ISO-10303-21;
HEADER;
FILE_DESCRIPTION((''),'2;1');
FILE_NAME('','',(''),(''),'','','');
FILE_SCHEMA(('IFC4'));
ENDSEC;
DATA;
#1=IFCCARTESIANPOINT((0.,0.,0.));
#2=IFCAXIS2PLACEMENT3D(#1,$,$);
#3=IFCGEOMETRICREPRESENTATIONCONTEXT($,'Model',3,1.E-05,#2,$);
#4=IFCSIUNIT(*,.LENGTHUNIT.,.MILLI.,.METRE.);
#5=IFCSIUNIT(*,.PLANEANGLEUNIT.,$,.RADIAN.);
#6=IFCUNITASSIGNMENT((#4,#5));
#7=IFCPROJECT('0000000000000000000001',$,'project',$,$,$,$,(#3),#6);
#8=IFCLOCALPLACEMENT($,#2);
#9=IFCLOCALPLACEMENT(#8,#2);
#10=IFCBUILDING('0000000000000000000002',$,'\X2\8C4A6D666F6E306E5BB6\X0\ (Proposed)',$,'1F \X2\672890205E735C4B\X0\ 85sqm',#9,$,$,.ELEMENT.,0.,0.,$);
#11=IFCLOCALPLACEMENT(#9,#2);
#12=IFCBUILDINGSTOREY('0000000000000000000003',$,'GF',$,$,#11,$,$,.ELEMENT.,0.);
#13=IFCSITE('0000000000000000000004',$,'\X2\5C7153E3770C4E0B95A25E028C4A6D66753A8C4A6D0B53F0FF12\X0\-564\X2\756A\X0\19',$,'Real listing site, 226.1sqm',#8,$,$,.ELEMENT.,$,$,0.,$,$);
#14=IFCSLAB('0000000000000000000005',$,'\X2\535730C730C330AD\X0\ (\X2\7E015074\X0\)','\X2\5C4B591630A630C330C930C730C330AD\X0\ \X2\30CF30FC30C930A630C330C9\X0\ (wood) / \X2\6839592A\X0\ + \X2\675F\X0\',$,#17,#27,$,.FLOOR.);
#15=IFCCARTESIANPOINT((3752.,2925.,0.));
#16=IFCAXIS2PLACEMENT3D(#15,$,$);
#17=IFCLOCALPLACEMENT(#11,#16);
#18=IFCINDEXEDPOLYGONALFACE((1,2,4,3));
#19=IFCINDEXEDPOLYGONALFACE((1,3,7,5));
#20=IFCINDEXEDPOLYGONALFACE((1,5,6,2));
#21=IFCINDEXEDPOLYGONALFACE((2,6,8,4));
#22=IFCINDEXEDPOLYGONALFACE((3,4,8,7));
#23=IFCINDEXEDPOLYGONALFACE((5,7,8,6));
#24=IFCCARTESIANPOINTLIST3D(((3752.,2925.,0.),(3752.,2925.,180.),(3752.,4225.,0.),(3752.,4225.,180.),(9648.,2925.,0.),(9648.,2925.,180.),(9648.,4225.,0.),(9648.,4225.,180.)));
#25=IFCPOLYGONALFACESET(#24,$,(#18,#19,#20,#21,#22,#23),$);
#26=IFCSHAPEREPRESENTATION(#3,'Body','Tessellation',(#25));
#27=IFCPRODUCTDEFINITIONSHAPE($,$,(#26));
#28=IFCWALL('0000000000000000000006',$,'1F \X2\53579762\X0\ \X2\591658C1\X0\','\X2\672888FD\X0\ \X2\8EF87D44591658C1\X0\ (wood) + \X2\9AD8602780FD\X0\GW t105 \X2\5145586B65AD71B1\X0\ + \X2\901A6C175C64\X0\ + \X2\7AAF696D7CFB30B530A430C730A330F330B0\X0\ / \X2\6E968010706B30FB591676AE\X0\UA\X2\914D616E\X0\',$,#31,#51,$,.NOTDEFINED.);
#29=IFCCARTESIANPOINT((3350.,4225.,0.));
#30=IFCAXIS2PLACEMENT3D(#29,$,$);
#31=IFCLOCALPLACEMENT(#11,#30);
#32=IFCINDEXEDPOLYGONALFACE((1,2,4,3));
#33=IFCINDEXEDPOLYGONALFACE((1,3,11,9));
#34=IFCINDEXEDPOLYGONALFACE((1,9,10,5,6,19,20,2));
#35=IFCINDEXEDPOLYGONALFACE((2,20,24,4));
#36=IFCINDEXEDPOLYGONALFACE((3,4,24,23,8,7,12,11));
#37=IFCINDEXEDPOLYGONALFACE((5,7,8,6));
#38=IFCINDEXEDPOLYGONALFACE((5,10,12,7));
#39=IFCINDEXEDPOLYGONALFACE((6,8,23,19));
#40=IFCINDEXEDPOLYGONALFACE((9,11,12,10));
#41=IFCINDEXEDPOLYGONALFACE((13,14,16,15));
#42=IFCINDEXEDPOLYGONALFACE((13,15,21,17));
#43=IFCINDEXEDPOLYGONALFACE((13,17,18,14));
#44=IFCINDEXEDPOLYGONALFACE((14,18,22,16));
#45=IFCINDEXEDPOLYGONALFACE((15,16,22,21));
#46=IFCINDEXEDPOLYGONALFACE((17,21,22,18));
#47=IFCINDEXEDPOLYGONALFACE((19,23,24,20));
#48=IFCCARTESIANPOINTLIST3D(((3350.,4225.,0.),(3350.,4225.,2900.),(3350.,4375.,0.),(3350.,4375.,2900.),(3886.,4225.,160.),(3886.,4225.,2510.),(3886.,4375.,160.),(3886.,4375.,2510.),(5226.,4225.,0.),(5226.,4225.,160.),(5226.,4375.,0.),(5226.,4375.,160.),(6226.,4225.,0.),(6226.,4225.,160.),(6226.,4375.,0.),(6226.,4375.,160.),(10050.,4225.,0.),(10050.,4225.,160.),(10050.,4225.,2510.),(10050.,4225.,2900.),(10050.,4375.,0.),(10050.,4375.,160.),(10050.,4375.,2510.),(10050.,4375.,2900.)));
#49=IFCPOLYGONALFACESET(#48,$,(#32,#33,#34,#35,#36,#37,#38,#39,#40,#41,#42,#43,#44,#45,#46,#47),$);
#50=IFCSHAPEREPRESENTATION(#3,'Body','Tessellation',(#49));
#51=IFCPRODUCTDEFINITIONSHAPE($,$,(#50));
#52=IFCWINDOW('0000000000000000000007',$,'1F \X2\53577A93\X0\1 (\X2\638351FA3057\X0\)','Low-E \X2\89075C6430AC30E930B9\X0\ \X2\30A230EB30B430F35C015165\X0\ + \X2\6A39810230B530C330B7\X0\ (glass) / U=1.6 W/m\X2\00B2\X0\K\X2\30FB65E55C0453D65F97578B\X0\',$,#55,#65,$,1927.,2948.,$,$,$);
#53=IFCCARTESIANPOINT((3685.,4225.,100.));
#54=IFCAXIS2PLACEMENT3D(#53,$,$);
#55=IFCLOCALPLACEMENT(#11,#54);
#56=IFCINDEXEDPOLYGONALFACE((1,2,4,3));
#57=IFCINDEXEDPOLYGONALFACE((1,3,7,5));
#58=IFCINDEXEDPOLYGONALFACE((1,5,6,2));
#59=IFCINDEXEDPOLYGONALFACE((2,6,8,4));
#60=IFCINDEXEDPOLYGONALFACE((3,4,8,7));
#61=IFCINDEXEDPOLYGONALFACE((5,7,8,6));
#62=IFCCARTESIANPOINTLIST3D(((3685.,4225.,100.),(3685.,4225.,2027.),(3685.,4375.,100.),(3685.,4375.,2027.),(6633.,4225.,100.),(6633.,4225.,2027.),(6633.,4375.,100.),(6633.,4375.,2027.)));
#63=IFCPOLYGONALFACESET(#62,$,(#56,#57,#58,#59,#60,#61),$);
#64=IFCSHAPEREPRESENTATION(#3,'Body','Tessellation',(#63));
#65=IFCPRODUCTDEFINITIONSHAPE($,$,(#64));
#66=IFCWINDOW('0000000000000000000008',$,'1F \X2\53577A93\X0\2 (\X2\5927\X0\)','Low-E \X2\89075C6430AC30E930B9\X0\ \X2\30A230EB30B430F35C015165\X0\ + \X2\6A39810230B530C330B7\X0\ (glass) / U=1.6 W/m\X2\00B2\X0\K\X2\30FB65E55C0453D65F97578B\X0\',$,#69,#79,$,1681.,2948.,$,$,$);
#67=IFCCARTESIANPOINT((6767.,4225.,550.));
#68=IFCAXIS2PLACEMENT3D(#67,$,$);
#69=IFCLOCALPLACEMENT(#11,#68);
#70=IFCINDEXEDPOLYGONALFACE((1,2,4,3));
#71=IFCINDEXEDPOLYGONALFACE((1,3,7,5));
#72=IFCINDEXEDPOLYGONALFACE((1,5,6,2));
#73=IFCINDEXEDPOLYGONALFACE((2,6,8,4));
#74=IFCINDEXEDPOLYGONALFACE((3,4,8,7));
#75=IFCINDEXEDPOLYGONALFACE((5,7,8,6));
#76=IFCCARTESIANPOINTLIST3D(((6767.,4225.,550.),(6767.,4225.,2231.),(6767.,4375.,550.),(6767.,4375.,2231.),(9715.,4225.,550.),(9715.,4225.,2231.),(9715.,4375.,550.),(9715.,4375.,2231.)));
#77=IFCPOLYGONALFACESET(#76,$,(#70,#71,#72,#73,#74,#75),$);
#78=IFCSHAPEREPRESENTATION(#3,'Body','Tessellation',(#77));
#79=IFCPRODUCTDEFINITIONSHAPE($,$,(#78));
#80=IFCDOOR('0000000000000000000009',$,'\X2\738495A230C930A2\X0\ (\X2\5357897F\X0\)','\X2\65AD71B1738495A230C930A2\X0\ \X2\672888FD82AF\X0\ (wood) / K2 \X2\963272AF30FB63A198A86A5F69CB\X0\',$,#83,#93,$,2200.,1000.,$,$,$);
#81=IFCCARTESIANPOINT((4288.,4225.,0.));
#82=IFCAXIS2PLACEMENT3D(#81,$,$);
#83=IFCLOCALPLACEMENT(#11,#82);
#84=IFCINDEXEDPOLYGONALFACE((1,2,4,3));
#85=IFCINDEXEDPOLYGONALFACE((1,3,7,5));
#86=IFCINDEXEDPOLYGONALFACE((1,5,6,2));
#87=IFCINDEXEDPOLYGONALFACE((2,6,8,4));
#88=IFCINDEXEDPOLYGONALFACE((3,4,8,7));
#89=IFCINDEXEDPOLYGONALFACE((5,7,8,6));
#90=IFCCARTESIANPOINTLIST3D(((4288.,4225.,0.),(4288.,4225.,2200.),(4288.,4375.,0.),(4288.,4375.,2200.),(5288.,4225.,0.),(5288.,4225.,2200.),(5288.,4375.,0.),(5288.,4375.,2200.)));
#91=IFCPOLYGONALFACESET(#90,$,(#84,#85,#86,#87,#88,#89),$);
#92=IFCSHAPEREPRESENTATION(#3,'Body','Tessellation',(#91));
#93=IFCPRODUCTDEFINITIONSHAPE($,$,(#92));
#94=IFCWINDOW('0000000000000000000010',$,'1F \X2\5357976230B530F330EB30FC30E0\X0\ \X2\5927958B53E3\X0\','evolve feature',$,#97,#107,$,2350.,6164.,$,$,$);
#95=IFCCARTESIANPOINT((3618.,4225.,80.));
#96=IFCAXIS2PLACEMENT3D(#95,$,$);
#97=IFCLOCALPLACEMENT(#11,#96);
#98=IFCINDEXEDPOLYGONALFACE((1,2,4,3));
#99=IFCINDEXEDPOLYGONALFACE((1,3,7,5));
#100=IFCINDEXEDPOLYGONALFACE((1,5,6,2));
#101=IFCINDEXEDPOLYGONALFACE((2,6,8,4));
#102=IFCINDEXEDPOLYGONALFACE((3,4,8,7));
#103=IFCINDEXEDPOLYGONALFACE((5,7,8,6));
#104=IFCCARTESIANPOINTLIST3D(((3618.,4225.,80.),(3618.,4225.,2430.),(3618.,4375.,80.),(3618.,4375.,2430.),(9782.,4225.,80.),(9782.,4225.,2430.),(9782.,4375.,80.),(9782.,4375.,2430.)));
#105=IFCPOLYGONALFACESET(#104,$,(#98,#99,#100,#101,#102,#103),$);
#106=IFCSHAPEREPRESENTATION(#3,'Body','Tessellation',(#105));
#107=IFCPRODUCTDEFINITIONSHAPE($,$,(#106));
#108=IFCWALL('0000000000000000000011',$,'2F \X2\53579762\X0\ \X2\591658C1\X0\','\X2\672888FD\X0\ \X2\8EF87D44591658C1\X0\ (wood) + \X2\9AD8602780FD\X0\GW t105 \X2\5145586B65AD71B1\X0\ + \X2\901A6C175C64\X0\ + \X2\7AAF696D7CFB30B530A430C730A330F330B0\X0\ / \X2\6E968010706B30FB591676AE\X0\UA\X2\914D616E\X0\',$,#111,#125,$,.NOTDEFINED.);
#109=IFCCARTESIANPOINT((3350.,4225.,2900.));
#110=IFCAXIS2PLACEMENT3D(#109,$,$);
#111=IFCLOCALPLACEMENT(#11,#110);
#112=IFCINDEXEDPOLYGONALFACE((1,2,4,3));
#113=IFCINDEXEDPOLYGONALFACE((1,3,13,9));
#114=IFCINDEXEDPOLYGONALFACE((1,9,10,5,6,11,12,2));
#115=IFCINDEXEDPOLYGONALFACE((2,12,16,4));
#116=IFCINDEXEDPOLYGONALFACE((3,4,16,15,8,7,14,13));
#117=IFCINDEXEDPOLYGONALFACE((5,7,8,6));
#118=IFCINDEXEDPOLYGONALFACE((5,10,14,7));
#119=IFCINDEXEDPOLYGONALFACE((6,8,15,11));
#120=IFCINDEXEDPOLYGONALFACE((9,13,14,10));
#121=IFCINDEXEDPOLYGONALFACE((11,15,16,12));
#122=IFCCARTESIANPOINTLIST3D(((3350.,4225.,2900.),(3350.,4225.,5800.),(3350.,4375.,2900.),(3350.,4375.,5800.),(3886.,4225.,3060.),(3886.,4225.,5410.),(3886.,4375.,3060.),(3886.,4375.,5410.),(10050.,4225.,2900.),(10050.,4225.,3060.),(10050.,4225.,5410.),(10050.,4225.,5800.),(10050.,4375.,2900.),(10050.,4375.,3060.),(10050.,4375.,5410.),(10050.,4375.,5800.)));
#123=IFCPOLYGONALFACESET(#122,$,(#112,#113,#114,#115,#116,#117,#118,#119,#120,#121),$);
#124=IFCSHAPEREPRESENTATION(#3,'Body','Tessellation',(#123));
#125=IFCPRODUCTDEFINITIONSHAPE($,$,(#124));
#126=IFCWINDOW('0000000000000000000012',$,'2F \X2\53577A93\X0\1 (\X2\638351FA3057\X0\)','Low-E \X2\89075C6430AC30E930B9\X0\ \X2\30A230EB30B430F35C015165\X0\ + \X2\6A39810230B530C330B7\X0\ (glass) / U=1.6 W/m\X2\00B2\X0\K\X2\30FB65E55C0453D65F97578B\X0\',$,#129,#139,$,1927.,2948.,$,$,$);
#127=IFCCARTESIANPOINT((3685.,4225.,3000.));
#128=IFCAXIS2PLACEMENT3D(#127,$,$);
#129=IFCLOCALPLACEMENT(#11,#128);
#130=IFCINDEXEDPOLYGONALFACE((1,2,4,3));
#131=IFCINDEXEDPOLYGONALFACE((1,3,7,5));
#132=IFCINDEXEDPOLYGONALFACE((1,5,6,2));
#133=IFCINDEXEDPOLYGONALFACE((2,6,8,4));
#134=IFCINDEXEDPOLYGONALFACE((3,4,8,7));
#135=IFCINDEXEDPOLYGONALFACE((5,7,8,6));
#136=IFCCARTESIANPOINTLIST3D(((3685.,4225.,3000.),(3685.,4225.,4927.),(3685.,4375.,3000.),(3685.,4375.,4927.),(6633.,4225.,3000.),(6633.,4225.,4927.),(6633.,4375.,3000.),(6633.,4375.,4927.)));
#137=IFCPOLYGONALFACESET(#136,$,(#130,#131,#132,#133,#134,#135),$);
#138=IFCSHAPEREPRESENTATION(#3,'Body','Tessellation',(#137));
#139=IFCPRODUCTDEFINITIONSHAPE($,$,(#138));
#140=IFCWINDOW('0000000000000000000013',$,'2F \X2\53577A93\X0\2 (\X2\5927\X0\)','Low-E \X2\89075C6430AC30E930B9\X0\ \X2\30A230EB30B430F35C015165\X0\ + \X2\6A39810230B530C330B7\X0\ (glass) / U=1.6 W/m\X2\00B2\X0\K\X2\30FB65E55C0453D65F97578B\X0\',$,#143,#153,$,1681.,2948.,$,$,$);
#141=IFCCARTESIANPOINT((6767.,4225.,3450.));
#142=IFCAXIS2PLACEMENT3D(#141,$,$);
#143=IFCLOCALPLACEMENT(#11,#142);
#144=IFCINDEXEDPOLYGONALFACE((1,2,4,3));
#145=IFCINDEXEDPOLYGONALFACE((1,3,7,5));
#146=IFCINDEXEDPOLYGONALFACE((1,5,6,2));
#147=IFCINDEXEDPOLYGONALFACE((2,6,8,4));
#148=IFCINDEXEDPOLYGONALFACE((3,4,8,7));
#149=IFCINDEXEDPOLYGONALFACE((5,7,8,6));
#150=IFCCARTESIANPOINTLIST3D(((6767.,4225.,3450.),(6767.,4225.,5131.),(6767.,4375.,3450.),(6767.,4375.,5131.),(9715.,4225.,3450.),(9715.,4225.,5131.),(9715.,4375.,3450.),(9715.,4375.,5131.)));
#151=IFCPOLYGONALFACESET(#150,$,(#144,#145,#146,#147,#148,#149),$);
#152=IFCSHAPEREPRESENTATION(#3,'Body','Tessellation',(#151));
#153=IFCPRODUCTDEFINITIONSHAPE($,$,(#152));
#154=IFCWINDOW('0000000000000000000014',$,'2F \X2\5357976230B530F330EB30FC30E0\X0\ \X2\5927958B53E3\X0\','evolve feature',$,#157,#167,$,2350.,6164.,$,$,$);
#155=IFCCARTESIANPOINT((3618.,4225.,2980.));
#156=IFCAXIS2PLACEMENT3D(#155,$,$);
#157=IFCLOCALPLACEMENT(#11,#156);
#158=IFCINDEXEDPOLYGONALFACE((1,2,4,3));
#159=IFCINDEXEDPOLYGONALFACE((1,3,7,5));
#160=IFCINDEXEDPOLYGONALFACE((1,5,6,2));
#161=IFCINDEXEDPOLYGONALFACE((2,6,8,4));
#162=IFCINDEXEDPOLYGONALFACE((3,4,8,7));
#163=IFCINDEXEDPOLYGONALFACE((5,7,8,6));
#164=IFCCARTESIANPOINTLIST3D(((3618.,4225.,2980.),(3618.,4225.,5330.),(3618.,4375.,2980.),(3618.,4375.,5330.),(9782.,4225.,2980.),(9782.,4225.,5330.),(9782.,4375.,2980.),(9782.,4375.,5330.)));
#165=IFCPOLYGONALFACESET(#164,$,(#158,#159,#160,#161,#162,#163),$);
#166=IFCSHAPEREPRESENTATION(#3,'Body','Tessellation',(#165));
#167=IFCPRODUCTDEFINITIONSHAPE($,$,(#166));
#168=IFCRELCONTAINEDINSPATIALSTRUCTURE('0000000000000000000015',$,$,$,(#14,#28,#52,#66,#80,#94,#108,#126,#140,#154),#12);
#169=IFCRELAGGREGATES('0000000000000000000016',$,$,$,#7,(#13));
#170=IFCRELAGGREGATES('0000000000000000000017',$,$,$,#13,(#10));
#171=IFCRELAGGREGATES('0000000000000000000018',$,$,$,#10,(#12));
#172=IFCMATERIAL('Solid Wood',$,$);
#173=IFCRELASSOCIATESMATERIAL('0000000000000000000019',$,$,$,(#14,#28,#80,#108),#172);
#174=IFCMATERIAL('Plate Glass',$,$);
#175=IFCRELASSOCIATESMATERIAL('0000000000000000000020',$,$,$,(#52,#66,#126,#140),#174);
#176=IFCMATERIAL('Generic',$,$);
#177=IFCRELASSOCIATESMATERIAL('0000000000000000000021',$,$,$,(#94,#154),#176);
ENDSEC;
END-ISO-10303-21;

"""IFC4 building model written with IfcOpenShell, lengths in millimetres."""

from ifc_helpers import new_model, si_unit, frame, frame_2d, origin, place, context, project, spatial, rectangle, extrude, material, element, fill, save


model = new_model("IFC4")

# Units and contexts
model_context = context("Model", 3, precision=1e-05, world=origin())
ifc_project = project(units=[si_unit("LENGTHUNIT", "METRE", prefix="MILLI"), si_unit("PLANEANGLEUNIT", "RADIAN")], contexts=[model_context])

# Site, building, storey
site_placement = place(None, origin())
site = spatial("IfcSite", under=ifc_project, at=site_placement, Name="山口県下関市豊浦町豊洋台２-564番19", ObjectType="Real listing site, 226.1sqm", CompositionType="ELEMENT", RefElevation=0.0)
building_placement = place(site_placement, origin())
building = spatial("IfcBuilding", under=site, at=building_placement, Name="豊浦潮の家 (Proposed)", ObjectType="1F 木造平屋 85sqm", CompositionType="ELEMENT", ElevationOfRefHeight=0.0, ElevationOfTerrain=0.0)
storey_placement = place(building_placement, origin())
storey = spatial("IfcBuildingStorey", under=building, at=storey_placement, Name="GF", CompositionType="ELEMENT", Elevation=0.0)

# Slab
ifc_material_1 = material(Name="Solid Wood")
slab_1_placement = place(storey_placement, frame((3752.0, 2925.0, 0.0)))
element("IfcSlab", 1, at=slab_1_placement, inside=storey, material=ifc_material_1, Name="南デッキ (縁側)", Description="屋外ウッドデッキ ハードウッド (wood) / 根太 + 束", PredefinedType="FLOOR", context=model_context, shape_type="SweptSolid", body=[
    extrude(rectangle(XDim=5896.0, YDim=1300.0, at=frame_2d((2948.0, 650.0))), frame((3752.0, 2925.0, 0.0)), (0.0, 0.0, 1.0), 180.0),
])
ifc_material_2 = material(Name="Generic")

# Wall, openings, windows, door
wall_1_placement = place(storey_placement, frame((3350.0, 4225.0, 0.0)))
wall_1 = element("IfcWall", 2, at=wall_1_placement, inside=storey, material=ifc_material_1, Name="1F 南面 外壁", Description="木製 軸組外壁 (wood) + 高性能GW t105 充填断熱 + 通気層 + 窯業系サイディング / 準耐火・外皮UA配慮", PredefinedType="NOTDEFINED", context=model_context, shape_type="SweptSolid", body=[
    extrude(rectangle(XDim=6700.0, YDim=150.0, at=frame_2d((3350.0, 75.0))), frame((3350.0, 4225.0, 0.0)), (0.0, 0.0, 1.0), 2900.0),
])
opening_1_placement = place(storey_placement, frame((3685.0, 4225.0, 100.0)))
opening_1 = element("IfcOpeningElement", 3, at=opening_1_placement, cuts=wall_1, PredefinedType="NOTDEFINED", context=model_context, shape_type="SweptSolid", body=[
    extrude(rectangle(XDim=2948.0, YDim=150.0, at=frame_2d((1474.0, 75.0))), frame((3685.0, 4225.0, 100.0)), (0.0, 0.0, 1.0), 1927.0),
])
opening_2_placement = place(storey_placement, frame((6767.0, 4225.0, 550.0)))
opening_2 = element("IfcOpeningElement", 4, at=opening_2_placement, cuts=wall_1, PredefinedType="NOTDEFINED", context=model_context, shape_type="SweptSolid", body=[
    extrude(rectangle(XDim=2948.0, YDim=150.0, at=frame_2d((1474.0, 75.0))), frame((6767.0, 4225.0, 550.0)), (0.0, 0.0, 1.0), 1681.0),
])
opening_3_placement = place(storey_placement, frame((4288.0, 4225.0, 0.0)))
opening_3 = element("IfcOpeningElement", 5, at=opening_3_placement, cuts=wall_1, PredefinedType="NOTDEFINED", context=model_context, shape_type="SweptSolid", body=[
    extrude(rectangle(XDim=1000.0, YDim=150.0, at=frame_2d((500.0, 75.0))), frame((4288.0, 4225.0, 0.0)), (0.0, 0.0, 1.0), 2200.0),
])
opening_4_placement = place(storey_placement, frame((3618.0, 4225.0, 80.0)))
opening_4 = element("IfcOpeningElement", 6, at=opening_4_placement, cuts=wall_1, PredefinedType="NOTDEFINED", context=model_context, shape_type="SweptSolid", body=[
    extrude(rectangle(XDim=6164.0, YDim=150.0, at=frame_2d((3082.0, 75.0))), frame((3618.0, 4225.0, 80.0)), (0.0, 0.0, 1.0), 2350.0),
])
ifc_material_3 = material(Name="Plate Glass")
window_1_placement = place(storey_placement, frame((3685.0, 4225.0, 100.0)))
window_1 = element("IfcWindow", 7, at=window_1_placement, inside=storey, material=ifc_material_3, Name="1F 南窓1 (掃出し)", Description="Low-E 複層ガラス アルゴン封入 + 樹脂サッシ (glass) / U=1.6 W/m²K・日射取得型", OverallHeight=1927.0, OverallWidth=2948.0, context=model_context, shape_type="SweptSolid", body=[
    extrude(rectangle(XDim=2948.0, YDim=150.0, at=frame_2d((1474.0, 75.0))), frame((3685.0, 4225.0, 100.0)), (0.0, 0.0, 1.0), 1927.0),
])
fill(opening_1, window_1)
window_2_placement = place(storey_placement, frame((6767.0, 4225.0, 550.0)))
window_2 = element("IfcWindow", 8, at=window_2_placement, inside=storey, material=ifc_material_3, Name="1F 南窓2 (大)", Description="Low-E 複層ガラス アルゴン封入 + 樹脂サッシ (glass) / U=1.6 W/m²K・日射取得型", OverallHeight=1681.0, OverallWidth=2948.0, context=model_context, shape_type="SweptSolid", body=[
    extrude(rectangle(XDim=2948.0, YDim=150.0, at=frame_2d((1474.0, 75.0))), frame((6767.0, 4225.0, 550.0)), (0.0, 0.0, 1.0), 1681.0),
])
fill(opening_2, window_2)
door_placement = place(storey_placement, frame((4288.0, 4225.0, 0.0)))
door = element("IfcDoor", 9, at=door_placement, inside=storey, material=ifc_material_1, Name="玄関ドア (南西)", Description="断熱玄関ドア 木製芯 (wood) / K2 防犯・採風機構", OverallHeight=2200.0, OverallWidth=1000.0, context=model_context, shape_type="SweptSolid", body=[
    extrude(rectangle(XDim=1000.0, YDim=150.0, at=frame_2d((500.0, 75.0))), frame((4288.0, 4225.0, 0.0)), (0.0, 0.0, 1.0), 2200.0),
])
fill(opening_3, door)
window_3_placement = place(storey_placement, frame((3618.0, 4225.0, 80.0)))
window_3 = element("IfcWindow", 10, at=window_3_placement, inside=storey, material=ifc_material_2, Name="1F 南面サンルーム 大開口", Description="evolve feature", OverallHeight=2350.0, OverallWidth=6164.0, context=model_context, shape_type="SweptSolid", body=[
    extrude(rectangle(XDim=6164.0, YDim=150.0, at=frame_2d((3082.0, 75.0))), frame((3618.0, 4225.0, 80.0)), (0.0, 0.0, 1.0), 2350.0),
])
fill(opening_4, window_3)

# Wall, openings, windows
wall_2_placement = place(storey_placement, frame((3350.0, 4225.0, 2900.0)))
wall_2 = element("IfcWall", 11, at=wall_2_placement, inside=storey, material=ifc_material_1, Name="2F 南面 外壁", Description="木製 軸組外壁 (wood) + 高性能GW t105 充填断熱 + 通気層 + 窯業系サイディング / 準耐火・外皮UA配慮", PredefinedType="NOTDEFINED", context=model_context, shape_type="SweptSolid", body=[
    extrude(rectangle(XDim=6700.0, YDim=150.0, at=frame_2d((3350.0, 75.0))), frame((3350.0, 4225.0, 2900.0)), (0.0, 0.0, 1.0), 2900.0),
])
opening_5_placement = place(storey_placement, frame((3685.0, 4225.0, 3000.0)))
opening_5 = element("IfcOpeningElement", 12, at=opening_5_placement, cuts=wall_2, PredefinedType="NOTDEFINED", context=model_context, shape_type="SweptSolid", body=[
    extrude(rectangle(XDim=2948.0, YDim=150.0, at=frame_2d((1474.0, 75.0))), frame((3685.0, 4225.0, 3000.0)), (0.0, 0.0, 1.0), 1927.0),
])
opening_6_placement = place(storey_placement, frame((6767.0, 4225.0, 3450.0)))
opening_6 = element("IfcOpeningElement", 13, at=opening_6_placement, cuts=wall_2, PredefinedType="NOTDEFINED", context=model_context, shape_type="SweptSolid", body=[
    extrude(rectangle(XDim=2948.0, YDim=150.0, at=frame_2d((1474.0, 75.0))), frame((6767.0, 4225.0, 3450.0)), (0.0, 0.0, 1.0), 1681.0),
])
opening_7_placement = place(storey_placement, frame((3618.0, 4225.0, 2980.0)))
opening_7 = element("IfcOpeningElement", 14, at=opening_7_placement, cuts=wall_2, PredefinedType="NOTDEFINED", context=model_context, shape_type="SweptSolid", body=[
    extrude(rectangle(XDim=6164.0, YDim=150.0, at=frame_2d((3082.0, 75.0))), frame((3618.0, 4225.0, 2980.0)), (0.0, 0.0, 1.0), 2350.0),
])
window_4_placement = place(storey_placement, frame((3685.0, 4225.0, 3000.0)))
window_4 = element("IfcWindow", 15, at=window_4_placement, inside=storey, material=ifc_material_3, Name="2F 南窓1 (掃出し)", Description="Low-E 複層ガラス アルゴン封入 + 樹脂サッシ (glass) / U=1.6 W/m²K・日射取得型", OverallHeight=1927.0, OverallWidth=2948.0, context=model_context, shape_type="SweptSolid", body=[
    extrude(rectangle(XDim=2948.0, YDim=150.0, at=frame_2d((1474.0, 75.0))), frame((3685.0, 4225.0, 3000.0)), (0.0, 0.0, 1.0), 1927.0),
])
fill(opening_5, window_4)
window_5_placement = place(storey_placement, frame((6767.0, 4225.0, 3450.0)))
window_5 = element("IfcWindow", 16, at=window_5_placement, inside=storey, material=ifc_material_3, Name="2F 南窓2 (大)", Description="Low-E 複層ガラス アルゴン封入 + 樹脂サッシ (glass) / U=1.6 W/m²K・日射取得型", OverallHeight=1681.0, OverallWidth=2948.0, context=model_context, shape_type="SweptSolid", body=[
    extrude(rectangle(XDim=2948.0, YDim=150.0, at=frame_2d((1474.0, 75.0))), frame((6767.0, 4225.0, 3450.0)), (0.0, 0.0, 1.0), 1681.0),
])
fill(opening_6, window_5)
window_6_placement = place(storey_placement, frame((3618.0, 4225.0, 2980.0)))
window_6 = element("IfcWindow", 17, at=window_6_placement, inside=storey, material=ifc_material_2, Name="2F 南面サンルーム 大開口", Description="evolve feature", OverallHeight=2350.0, OverallWidth=6164.0, context=model_context, shape_type="SweptSolid", body=[
    extrude(rectangle(XDim=6164.0, YDim=150.0, at=frame_2d((3082.0, 75.0))), frame((3618.0, 4225.0, 2980.0)), (0.0, 0.0, 1.0), 2350.0),
])
fill(opening_7, window_6)

save(model, "model.ifc")
